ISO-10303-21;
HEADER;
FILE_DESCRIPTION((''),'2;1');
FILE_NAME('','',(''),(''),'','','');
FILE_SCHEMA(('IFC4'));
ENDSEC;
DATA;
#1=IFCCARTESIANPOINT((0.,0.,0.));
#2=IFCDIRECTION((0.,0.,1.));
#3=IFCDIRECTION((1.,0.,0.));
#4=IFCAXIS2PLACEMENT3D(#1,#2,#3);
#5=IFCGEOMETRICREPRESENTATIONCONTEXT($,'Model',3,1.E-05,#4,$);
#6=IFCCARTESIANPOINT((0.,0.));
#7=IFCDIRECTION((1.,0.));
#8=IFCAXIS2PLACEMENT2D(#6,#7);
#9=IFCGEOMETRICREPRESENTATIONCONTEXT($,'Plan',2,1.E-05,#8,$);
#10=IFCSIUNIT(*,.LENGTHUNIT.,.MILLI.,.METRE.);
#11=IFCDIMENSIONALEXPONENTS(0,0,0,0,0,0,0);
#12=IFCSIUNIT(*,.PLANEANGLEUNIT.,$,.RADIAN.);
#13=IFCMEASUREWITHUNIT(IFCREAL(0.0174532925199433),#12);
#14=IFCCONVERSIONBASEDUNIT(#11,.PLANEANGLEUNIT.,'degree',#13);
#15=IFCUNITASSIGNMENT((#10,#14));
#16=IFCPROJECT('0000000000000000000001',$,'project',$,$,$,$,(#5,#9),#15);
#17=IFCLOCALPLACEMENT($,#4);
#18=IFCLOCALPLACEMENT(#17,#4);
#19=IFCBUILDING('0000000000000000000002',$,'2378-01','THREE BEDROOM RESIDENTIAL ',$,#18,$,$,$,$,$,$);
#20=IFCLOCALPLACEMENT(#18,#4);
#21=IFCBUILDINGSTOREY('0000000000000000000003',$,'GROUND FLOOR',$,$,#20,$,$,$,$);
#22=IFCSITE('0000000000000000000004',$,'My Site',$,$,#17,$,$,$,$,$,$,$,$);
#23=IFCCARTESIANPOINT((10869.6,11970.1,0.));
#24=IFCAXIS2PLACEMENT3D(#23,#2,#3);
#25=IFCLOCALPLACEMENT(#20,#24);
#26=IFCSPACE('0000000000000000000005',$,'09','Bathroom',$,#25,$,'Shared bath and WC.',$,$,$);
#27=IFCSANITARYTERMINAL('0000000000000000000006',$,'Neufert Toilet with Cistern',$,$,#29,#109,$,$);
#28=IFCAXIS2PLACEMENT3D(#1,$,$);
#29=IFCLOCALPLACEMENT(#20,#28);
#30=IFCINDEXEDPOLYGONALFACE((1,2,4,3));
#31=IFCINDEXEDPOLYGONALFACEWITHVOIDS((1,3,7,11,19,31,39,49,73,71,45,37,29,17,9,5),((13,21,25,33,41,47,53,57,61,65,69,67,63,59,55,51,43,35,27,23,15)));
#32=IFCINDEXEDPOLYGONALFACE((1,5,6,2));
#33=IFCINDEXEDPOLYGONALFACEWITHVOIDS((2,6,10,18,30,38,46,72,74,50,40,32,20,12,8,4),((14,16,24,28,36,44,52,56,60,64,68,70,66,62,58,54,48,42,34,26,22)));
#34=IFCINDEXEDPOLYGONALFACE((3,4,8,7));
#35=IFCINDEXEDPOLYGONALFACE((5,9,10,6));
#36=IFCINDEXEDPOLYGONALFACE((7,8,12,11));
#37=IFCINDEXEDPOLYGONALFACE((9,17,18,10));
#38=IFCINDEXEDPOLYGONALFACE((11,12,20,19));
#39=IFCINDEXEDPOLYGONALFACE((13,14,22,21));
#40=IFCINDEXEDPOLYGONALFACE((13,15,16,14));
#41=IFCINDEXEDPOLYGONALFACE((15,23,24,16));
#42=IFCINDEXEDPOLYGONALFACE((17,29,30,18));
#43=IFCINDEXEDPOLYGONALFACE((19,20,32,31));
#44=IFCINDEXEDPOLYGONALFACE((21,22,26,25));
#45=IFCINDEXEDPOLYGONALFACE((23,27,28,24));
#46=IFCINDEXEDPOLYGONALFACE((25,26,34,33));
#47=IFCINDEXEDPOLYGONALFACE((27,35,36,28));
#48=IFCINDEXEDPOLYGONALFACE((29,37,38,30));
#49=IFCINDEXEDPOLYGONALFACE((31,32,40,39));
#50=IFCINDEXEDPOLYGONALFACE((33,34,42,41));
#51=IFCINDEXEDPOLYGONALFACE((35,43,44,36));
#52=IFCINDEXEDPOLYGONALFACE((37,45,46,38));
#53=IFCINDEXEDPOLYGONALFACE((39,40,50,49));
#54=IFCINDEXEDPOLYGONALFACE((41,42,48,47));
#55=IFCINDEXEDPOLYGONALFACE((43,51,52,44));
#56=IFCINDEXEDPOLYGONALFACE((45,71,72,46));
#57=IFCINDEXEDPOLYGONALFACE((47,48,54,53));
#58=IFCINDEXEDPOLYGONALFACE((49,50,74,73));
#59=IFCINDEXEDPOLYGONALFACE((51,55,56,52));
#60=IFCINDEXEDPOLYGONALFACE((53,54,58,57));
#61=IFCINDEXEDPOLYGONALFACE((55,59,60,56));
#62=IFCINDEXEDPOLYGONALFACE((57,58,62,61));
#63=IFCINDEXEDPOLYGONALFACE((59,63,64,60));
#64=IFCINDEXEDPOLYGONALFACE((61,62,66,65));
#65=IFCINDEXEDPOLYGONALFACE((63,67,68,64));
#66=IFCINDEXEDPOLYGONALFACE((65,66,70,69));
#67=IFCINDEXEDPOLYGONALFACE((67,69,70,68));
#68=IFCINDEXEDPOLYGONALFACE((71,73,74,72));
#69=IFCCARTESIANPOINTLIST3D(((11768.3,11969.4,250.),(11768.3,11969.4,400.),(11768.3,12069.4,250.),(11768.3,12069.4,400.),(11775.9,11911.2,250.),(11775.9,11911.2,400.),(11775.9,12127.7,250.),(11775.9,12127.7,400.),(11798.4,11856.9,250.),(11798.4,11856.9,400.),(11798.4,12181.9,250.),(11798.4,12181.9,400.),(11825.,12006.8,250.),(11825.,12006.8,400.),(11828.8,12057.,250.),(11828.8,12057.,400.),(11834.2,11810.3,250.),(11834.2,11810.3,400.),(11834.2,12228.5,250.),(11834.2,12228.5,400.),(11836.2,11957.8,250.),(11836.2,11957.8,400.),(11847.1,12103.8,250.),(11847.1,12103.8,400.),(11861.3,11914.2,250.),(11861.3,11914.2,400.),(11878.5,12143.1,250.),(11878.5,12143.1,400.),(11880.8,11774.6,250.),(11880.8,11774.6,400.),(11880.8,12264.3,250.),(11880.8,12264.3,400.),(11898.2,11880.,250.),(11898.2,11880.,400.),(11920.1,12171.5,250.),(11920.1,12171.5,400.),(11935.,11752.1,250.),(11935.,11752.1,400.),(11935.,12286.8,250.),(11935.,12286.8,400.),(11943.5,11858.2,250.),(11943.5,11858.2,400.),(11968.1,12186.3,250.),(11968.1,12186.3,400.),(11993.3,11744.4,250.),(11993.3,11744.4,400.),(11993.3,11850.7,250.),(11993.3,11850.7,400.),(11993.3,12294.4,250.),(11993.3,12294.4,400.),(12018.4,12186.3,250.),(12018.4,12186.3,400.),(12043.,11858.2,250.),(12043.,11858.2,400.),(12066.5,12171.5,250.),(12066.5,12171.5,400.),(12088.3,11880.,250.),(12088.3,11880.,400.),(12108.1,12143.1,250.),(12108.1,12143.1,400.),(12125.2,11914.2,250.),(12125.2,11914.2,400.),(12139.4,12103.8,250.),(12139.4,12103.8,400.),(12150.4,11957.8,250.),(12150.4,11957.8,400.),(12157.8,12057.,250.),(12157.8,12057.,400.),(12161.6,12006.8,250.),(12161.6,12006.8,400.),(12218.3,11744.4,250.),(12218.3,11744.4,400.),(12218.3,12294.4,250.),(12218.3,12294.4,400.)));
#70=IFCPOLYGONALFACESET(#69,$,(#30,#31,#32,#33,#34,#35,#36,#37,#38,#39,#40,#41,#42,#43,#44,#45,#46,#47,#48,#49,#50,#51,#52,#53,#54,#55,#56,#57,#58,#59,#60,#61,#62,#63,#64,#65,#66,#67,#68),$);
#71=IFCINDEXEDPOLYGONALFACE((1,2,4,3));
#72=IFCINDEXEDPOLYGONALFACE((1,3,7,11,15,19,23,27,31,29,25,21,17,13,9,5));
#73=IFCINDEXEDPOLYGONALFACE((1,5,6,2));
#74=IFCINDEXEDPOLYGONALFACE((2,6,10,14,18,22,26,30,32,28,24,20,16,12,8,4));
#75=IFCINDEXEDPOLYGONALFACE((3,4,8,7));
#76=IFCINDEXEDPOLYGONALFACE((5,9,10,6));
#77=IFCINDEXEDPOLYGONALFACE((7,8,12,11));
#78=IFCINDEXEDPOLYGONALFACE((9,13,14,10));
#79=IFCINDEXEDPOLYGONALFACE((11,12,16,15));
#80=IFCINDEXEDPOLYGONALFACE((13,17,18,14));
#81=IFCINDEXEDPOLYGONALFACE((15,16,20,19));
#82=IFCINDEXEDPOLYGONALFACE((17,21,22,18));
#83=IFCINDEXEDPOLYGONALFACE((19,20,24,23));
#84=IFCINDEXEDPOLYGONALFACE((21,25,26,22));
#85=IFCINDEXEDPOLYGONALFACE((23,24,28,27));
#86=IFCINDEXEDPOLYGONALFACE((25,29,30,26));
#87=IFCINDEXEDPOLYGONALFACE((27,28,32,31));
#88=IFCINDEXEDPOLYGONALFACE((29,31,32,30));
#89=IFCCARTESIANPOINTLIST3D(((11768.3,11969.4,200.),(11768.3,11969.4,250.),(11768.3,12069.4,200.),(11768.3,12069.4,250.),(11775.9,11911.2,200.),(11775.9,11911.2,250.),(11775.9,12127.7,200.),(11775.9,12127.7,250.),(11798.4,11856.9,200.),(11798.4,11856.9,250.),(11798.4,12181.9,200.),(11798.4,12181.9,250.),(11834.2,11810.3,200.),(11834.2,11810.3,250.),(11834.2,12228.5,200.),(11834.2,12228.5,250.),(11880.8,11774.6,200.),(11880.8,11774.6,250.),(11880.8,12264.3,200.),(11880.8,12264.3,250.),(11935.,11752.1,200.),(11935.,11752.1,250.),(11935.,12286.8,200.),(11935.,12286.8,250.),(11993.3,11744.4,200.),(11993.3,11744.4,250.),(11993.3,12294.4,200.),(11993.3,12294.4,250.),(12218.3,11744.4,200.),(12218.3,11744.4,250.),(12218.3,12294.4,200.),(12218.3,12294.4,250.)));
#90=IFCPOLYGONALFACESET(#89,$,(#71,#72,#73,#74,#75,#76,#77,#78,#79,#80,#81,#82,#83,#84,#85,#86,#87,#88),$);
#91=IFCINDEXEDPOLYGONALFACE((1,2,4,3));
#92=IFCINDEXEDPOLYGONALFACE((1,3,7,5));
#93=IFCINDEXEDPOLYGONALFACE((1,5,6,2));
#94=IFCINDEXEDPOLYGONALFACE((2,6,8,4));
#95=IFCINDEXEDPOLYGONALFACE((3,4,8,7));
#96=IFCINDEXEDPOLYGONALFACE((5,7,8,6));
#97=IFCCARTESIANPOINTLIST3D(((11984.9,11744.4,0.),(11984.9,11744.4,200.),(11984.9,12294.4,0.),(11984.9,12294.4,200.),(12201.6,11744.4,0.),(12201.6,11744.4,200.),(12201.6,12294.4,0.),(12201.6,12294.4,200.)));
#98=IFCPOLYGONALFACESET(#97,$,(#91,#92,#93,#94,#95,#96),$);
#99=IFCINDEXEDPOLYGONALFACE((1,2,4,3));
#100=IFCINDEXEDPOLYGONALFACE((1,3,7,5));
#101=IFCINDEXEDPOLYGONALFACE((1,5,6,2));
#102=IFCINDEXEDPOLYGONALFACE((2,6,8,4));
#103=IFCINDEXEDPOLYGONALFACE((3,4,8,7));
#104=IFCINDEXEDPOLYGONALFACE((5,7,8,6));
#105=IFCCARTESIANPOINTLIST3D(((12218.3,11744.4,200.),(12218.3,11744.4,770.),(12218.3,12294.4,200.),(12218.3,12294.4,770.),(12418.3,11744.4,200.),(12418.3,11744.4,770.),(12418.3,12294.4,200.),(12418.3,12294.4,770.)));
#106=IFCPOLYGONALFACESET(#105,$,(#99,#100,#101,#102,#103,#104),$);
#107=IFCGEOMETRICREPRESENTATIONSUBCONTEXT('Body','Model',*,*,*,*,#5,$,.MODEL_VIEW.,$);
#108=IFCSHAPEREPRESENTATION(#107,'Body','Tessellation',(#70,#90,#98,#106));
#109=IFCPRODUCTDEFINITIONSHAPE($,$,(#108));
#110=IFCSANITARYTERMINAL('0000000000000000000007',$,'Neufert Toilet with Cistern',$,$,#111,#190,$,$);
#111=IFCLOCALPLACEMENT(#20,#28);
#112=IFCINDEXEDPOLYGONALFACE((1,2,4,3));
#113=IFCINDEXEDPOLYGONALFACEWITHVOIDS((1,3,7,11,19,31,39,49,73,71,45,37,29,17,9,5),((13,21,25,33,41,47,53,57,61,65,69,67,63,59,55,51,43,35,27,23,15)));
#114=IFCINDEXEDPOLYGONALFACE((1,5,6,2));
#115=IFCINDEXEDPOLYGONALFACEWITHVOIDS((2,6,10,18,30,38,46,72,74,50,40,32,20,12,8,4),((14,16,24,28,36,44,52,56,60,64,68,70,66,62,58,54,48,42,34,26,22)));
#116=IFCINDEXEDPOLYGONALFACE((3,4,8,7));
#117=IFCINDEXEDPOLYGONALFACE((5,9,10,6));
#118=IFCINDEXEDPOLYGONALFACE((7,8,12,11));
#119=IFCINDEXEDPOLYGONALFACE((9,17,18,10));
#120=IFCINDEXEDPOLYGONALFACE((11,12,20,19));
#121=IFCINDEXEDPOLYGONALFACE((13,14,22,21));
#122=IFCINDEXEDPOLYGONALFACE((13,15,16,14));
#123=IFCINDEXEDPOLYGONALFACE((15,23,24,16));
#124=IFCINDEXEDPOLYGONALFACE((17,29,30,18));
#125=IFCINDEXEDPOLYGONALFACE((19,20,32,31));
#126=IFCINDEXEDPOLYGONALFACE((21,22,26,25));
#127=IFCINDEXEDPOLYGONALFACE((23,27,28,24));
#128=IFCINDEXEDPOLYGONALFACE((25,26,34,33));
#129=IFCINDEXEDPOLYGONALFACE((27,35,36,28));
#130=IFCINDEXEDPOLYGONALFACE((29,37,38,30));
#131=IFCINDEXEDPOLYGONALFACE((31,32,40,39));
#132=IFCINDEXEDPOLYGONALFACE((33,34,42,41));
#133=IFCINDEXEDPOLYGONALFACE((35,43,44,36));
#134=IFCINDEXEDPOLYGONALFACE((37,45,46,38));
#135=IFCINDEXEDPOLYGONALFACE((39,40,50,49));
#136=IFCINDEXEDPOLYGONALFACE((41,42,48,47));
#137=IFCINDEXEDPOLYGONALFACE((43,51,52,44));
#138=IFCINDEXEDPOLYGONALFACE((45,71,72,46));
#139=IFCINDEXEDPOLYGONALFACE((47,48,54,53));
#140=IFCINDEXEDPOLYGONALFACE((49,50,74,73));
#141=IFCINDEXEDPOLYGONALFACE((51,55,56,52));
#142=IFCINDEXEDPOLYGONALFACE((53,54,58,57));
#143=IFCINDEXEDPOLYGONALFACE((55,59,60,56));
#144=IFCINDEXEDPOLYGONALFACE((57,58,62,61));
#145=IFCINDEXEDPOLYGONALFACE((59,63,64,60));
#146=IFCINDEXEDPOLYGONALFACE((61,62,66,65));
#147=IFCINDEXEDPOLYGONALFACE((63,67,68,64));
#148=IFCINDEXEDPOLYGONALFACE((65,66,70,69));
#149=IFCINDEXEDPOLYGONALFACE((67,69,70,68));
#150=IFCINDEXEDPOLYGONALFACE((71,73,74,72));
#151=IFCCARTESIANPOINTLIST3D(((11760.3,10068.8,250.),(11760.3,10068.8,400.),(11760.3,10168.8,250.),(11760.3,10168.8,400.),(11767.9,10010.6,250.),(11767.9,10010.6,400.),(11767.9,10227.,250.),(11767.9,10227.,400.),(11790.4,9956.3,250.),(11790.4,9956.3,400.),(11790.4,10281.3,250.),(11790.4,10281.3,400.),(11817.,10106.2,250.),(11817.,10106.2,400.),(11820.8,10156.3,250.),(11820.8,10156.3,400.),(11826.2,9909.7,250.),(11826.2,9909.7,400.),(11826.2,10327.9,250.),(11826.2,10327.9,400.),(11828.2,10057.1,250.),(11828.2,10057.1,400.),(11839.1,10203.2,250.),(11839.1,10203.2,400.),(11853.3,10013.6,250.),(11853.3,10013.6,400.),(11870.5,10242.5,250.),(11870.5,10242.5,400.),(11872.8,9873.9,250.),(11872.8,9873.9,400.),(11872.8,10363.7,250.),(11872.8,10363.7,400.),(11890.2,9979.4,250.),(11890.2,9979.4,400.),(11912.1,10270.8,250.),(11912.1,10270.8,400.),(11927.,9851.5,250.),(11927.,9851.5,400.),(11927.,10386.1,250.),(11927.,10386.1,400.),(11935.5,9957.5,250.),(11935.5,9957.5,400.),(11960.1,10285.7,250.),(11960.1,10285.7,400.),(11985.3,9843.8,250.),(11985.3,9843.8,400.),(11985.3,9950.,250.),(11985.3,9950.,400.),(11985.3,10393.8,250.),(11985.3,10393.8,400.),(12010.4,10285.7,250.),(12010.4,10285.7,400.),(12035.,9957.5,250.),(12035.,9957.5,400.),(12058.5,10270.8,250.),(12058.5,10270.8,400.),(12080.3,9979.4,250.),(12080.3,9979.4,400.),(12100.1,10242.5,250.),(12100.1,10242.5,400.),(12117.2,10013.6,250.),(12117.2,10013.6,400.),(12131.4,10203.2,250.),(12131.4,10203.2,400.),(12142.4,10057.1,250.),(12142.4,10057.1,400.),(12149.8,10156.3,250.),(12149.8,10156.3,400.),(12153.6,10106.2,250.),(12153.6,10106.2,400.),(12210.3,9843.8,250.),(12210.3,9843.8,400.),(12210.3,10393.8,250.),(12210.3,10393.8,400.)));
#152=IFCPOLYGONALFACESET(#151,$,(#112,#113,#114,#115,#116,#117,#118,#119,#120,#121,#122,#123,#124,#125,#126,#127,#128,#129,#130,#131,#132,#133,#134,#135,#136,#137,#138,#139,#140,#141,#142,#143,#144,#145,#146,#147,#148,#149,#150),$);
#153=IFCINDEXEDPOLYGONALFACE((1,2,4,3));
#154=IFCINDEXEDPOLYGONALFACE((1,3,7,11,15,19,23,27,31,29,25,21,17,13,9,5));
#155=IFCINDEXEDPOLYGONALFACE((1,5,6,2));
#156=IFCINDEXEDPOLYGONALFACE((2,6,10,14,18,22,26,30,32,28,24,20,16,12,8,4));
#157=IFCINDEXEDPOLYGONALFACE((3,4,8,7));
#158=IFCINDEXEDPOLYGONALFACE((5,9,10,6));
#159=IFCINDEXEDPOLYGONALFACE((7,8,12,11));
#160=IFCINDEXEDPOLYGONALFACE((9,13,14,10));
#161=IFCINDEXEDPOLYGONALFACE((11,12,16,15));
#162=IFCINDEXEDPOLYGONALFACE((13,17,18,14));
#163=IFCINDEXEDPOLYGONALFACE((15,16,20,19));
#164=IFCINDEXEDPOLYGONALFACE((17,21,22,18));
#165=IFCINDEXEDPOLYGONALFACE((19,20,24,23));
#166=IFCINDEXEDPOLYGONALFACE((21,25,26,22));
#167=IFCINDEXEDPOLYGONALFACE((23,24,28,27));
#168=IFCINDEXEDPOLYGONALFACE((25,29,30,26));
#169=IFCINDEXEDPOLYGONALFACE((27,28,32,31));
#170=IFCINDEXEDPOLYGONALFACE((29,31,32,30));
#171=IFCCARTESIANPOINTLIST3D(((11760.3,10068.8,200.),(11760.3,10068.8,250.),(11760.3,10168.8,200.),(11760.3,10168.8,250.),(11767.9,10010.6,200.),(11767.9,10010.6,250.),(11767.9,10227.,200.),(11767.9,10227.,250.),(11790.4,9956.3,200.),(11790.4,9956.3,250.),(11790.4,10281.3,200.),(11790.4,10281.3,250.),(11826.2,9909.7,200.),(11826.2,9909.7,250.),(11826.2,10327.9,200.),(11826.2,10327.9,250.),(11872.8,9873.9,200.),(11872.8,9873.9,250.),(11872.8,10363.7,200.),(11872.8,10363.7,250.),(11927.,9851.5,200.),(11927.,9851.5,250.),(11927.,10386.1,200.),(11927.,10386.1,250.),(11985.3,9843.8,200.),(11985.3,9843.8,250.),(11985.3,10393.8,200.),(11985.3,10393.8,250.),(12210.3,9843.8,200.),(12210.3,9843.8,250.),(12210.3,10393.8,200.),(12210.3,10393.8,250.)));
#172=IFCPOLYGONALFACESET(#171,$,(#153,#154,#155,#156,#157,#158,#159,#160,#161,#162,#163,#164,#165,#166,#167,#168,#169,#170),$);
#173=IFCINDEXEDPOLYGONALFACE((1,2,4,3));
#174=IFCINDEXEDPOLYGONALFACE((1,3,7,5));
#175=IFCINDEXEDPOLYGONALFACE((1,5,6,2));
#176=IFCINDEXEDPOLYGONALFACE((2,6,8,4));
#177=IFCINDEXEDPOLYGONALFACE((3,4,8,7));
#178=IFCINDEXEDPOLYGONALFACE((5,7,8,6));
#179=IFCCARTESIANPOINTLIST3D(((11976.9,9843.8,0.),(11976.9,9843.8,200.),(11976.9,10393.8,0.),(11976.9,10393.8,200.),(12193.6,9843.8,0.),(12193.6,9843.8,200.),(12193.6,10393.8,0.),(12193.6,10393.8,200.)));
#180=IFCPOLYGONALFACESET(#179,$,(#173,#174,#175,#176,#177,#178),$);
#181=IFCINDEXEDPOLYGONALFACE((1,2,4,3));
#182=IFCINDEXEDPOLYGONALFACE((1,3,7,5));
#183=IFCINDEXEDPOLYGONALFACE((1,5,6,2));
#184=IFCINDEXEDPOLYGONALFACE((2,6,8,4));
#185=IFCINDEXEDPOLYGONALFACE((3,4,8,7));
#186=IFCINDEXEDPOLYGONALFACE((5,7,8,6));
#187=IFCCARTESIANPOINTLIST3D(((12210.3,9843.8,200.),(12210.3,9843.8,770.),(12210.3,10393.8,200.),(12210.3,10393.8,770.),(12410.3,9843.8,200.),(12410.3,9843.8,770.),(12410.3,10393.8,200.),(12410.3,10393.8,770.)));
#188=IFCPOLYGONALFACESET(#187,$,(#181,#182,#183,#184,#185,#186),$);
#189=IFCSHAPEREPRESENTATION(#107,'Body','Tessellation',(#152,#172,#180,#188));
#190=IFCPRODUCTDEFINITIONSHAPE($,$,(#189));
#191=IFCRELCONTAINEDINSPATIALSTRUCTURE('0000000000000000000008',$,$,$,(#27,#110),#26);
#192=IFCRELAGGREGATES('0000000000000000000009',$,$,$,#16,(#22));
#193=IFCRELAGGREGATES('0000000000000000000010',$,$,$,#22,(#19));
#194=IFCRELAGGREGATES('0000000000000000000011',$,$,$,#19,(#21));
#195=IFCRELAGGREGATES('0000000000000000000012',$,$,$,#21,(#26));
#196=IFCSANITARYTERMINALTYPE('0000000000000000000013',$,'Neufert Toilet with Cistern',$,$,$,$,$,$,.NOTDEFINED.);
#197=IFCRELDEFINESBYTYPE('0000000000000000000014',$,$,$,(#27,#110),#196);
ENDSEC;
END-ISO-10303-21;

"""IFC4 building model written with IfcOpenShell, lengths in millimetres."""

from ifc_helpers import new_model, entity, si_unit, converted_unit, frame, frame_2d, origin_with_axes, origin_2d_with_axis, place, context, subcontext, project, spatial, line, arc, indexed_curve, circle_curve, outline, extrude, shape, source, transform, mapped, type_object, type_shapes, element, save


model = new_model("IFC4")

# Units and contexts
model_context = context("Model", 3, precision=1e-05, world=origin_with_axes())
plan_context = context("Plan", 2, precision=1e-05, world=origin_2d_with_axis())
body_context_1 = subcontext(model_context, "Body", "Model", "MODEL_VIEW")
body_context_2 = subcontext(plan_context, "Body", "Plan", "PLAN_VIEW")
ifc_project = project(units=[si_unit("LENGTHUNIT", "METRE", prefix="MILLI"), converted_unit("PLANEANGLEUNIT", "degree", entity("IfcReal", 0.0174532925199433), si_unit("PLANEANGLEUNIT", "RADIAN"), dimensions=[0, 0, 0, 0, 0, 0, 0])], contexts=[model_context, plan_context])

# Site, building, storey
site_placement = place(None, origin_with_axes())
site = spatial("IfcSite", under=ifc_project, at=site_placement, Name="My Site")
building_placement = place(site_placement, origin_with_axes())
building = spatial("IfcBuilding", under=site, at=building_placement, Name="2378-01", Description="THREE BEDROOM RESIDENTIAL ")
storey_placement = place(building_placement, origin_with_axes())
storey = spatial("IfcBuildingStorey", under=building, at=storey_placement, Name="GROUND FLOOR")

# Shared definitions
space_placement = place(storey_placement, frame((10869.6, 11970.1, 0.0), z_axis=(0.0, 0.0, 1.0), x_axis=(1.0, 0.0, 0.0)))
space = spatial("IfcSpace", under=storey, at=space_placement, Name="09", Description="Bathroom", LongName="Shared bath and WC.")

# Sanitary terminals
sanitary_terminal_type_1 = type_object("IfcSanitaryTerminalType", Name="Neufert Toilet with Cistern", PredefinedType="NOTDEFINED")
shared_shape_1 = source(origin_with_axes(), body_context_1, "Body", "SweptSolid", [
    extrude(outline(indexed_curve([(-275.0, -200.0), (275.0, -200.0), (275.0, -425.0), (209.1, -584.1), (50.0, -650.0), (-50.0, -650.0), (-209.1, -584.1), (-275.0, -425.0)], segments=[line(1, 2), line(2, 3), arc(3, 4, 5), line(5, 6), arc(6, 7, 8), line(8, 1)]), holes=[circle_curve(frame_2d((0.0, -425.0)), 168.8)]), frame((0.0, 0.0, 250.0), z_axis=(0.0, 0.0, 1.0), x_axis=(1.0, 0.0, 0.0)), (0.0, 0.0, 1.0), 150.0),
    extrude(outline(indexed_curve([(-275.0, -200.0), (275.0, -200.0), (275.0, -425.0), (209.1, -584.1), (50.0, -650.0), (-50.0, -650.0), (-209.1, -584.1), (-275.0, -425.0)], segments=[line(1, 2), line(2, 3), arc(3, 4, 5), line(5, 6), arc(6, 7, 8), line(8, 1)])), frame((0.0, 0.0, 200.0), z_axis=(0.0, 0.0, 1.0), x_axis=(1.0, 0.0, 0.0)), (0.0, 0.0, 1.0), 50.0),
    extrude(outline(indexed_curve([(-275.0, -216.7), (275.0, -216.7), (275.0, -433.3), (-275.0, -433.3)], segments=[line(1, 2, 3, 4, 1)])), origin_with_axes(), (0.0, 0.0, 1.0), 200.0),
    extrude(outline(indexed_curve([(-275.0, 0.0), (275.0, 0.0), (275.0, -200.0), (-275.0, -200.0)], segments=[line(1, 2, 3, 4, 1)])), frame((0.0, 0.0, 200.0), z_axis=(0.0, 0.0, 1.0), x_axis=(1.0, 0.0, 0.0)), (0.0, 0.0, 1.0), 570.0),
])
shared_shape_2 = source(origin_with_axes(), body_context_2, "Body", "Curve2D", [
    entity("IfcIndexedPolyCurve", entity("IfcCartesianPointList2D", [[-275.0, 0.0], [275.0, 0.0], [275.0, -200.0], [-275.0, -200.0]]), [entity("IfcLineIndex", [1, 2, 3, 4, 1])]),
    entity("IfcIndexedPolyCurve", entity("IfcCartesianPointList2D", [[165.0, -200.0], [192.5, -335.0]])),
    entity("IfcTrimmedCurve", entity("IfcEllipse", entity("IfcAxis2Placement2D", entity("IfcCartesianPoint", [0.0, -335.0]), entity("IfcDirection", [1.0, 0.0])), 192.5, 315.0), [entity("IfcCartesianPoint", [-192.5, -335.0])], [entity("IfcCartesianPoint", [192.5, -335.0])], True, "CARTESIAN"),
    entity("IfcIndexedPolyCurve", entity("IfcCartesianPointList2D", [[-165.0, -200.0], [-192.5, -335.0]])),
    entity("IfcEllipse", entity("IfcAxis2Placement2D", entity("IfcCartesianPoint", [0.0, -452.0]), entity("IfcDirection", [1.0, 0.0])), 131.2, 157.5),
    entity("IfcIndexedPolyCurve", entity("IfcCartesianPointList2D", [[-34.4, -452.0], [-34.4, -429.5], [34.4, -429.5], [34.4, -452.0]])),
    entity("IfcTrimmedCurve", entity("IfcEllipse", entity("IfcAxis2Placement2D", entity("IfcCartesianPoint", [0.0, -452.0]), entity("IfcDirection", [1.0, 0.0])), 34.4, 22.5), [entity("IfcCartesianPoint", [-34.4, -452.0])], [entity("IfcCartesianPoint", [34.4, -452.0])], True, "CARTESIAN"),
])
type_shapes(sanitary_terminal_type_1, [shared_shape_1, shared_shape_2])
for number, where, z_axis, x_axis, name in (
    (1, (1548.7, 49.3, 0.0), (0.0, 0.0, 1.0), (0.0, -1.0, 0.0), "Neufert Toilet with Cistern"),
    (2, (1540.7, -1851.3, 0.0), (0.0, 0.0, 1.0), (0.0, -1.0, 0.0), "Neufert Toilet with Cistern"),
):
    element("IfcSanitaryTerminal", number, at=place(space_placement, frame(where, z_axis=z_axis, x_axis=x_axis)), inside=space, type_object=sanitary_terminal_type_1, Name=name, shapes=[
        shape(body_context_1, "Body", "MappedRepresentation", [mapped(shared_shape_1, transform((0.0, 0.0, 0.0), x_axis=(1.0, 0.0, 0.0), y_axis=(0.0, 1.0, 0.0), z_axis=(0.0, 0.0, 1.0), scale=1.0))]),
        shape(body_context_2, "Body", "MappedRepresentation", [mapped(shared_shape_2, transform((0.0, 0.0, 0.0), x_axis=(1.0, 0.0, 0.0), y_axis=(0.0, 1.0, 0.0), z_axis=(0.0, 0.0, 1.0), scale=1.0))]),
    ])

save(model, "model.ifc")
